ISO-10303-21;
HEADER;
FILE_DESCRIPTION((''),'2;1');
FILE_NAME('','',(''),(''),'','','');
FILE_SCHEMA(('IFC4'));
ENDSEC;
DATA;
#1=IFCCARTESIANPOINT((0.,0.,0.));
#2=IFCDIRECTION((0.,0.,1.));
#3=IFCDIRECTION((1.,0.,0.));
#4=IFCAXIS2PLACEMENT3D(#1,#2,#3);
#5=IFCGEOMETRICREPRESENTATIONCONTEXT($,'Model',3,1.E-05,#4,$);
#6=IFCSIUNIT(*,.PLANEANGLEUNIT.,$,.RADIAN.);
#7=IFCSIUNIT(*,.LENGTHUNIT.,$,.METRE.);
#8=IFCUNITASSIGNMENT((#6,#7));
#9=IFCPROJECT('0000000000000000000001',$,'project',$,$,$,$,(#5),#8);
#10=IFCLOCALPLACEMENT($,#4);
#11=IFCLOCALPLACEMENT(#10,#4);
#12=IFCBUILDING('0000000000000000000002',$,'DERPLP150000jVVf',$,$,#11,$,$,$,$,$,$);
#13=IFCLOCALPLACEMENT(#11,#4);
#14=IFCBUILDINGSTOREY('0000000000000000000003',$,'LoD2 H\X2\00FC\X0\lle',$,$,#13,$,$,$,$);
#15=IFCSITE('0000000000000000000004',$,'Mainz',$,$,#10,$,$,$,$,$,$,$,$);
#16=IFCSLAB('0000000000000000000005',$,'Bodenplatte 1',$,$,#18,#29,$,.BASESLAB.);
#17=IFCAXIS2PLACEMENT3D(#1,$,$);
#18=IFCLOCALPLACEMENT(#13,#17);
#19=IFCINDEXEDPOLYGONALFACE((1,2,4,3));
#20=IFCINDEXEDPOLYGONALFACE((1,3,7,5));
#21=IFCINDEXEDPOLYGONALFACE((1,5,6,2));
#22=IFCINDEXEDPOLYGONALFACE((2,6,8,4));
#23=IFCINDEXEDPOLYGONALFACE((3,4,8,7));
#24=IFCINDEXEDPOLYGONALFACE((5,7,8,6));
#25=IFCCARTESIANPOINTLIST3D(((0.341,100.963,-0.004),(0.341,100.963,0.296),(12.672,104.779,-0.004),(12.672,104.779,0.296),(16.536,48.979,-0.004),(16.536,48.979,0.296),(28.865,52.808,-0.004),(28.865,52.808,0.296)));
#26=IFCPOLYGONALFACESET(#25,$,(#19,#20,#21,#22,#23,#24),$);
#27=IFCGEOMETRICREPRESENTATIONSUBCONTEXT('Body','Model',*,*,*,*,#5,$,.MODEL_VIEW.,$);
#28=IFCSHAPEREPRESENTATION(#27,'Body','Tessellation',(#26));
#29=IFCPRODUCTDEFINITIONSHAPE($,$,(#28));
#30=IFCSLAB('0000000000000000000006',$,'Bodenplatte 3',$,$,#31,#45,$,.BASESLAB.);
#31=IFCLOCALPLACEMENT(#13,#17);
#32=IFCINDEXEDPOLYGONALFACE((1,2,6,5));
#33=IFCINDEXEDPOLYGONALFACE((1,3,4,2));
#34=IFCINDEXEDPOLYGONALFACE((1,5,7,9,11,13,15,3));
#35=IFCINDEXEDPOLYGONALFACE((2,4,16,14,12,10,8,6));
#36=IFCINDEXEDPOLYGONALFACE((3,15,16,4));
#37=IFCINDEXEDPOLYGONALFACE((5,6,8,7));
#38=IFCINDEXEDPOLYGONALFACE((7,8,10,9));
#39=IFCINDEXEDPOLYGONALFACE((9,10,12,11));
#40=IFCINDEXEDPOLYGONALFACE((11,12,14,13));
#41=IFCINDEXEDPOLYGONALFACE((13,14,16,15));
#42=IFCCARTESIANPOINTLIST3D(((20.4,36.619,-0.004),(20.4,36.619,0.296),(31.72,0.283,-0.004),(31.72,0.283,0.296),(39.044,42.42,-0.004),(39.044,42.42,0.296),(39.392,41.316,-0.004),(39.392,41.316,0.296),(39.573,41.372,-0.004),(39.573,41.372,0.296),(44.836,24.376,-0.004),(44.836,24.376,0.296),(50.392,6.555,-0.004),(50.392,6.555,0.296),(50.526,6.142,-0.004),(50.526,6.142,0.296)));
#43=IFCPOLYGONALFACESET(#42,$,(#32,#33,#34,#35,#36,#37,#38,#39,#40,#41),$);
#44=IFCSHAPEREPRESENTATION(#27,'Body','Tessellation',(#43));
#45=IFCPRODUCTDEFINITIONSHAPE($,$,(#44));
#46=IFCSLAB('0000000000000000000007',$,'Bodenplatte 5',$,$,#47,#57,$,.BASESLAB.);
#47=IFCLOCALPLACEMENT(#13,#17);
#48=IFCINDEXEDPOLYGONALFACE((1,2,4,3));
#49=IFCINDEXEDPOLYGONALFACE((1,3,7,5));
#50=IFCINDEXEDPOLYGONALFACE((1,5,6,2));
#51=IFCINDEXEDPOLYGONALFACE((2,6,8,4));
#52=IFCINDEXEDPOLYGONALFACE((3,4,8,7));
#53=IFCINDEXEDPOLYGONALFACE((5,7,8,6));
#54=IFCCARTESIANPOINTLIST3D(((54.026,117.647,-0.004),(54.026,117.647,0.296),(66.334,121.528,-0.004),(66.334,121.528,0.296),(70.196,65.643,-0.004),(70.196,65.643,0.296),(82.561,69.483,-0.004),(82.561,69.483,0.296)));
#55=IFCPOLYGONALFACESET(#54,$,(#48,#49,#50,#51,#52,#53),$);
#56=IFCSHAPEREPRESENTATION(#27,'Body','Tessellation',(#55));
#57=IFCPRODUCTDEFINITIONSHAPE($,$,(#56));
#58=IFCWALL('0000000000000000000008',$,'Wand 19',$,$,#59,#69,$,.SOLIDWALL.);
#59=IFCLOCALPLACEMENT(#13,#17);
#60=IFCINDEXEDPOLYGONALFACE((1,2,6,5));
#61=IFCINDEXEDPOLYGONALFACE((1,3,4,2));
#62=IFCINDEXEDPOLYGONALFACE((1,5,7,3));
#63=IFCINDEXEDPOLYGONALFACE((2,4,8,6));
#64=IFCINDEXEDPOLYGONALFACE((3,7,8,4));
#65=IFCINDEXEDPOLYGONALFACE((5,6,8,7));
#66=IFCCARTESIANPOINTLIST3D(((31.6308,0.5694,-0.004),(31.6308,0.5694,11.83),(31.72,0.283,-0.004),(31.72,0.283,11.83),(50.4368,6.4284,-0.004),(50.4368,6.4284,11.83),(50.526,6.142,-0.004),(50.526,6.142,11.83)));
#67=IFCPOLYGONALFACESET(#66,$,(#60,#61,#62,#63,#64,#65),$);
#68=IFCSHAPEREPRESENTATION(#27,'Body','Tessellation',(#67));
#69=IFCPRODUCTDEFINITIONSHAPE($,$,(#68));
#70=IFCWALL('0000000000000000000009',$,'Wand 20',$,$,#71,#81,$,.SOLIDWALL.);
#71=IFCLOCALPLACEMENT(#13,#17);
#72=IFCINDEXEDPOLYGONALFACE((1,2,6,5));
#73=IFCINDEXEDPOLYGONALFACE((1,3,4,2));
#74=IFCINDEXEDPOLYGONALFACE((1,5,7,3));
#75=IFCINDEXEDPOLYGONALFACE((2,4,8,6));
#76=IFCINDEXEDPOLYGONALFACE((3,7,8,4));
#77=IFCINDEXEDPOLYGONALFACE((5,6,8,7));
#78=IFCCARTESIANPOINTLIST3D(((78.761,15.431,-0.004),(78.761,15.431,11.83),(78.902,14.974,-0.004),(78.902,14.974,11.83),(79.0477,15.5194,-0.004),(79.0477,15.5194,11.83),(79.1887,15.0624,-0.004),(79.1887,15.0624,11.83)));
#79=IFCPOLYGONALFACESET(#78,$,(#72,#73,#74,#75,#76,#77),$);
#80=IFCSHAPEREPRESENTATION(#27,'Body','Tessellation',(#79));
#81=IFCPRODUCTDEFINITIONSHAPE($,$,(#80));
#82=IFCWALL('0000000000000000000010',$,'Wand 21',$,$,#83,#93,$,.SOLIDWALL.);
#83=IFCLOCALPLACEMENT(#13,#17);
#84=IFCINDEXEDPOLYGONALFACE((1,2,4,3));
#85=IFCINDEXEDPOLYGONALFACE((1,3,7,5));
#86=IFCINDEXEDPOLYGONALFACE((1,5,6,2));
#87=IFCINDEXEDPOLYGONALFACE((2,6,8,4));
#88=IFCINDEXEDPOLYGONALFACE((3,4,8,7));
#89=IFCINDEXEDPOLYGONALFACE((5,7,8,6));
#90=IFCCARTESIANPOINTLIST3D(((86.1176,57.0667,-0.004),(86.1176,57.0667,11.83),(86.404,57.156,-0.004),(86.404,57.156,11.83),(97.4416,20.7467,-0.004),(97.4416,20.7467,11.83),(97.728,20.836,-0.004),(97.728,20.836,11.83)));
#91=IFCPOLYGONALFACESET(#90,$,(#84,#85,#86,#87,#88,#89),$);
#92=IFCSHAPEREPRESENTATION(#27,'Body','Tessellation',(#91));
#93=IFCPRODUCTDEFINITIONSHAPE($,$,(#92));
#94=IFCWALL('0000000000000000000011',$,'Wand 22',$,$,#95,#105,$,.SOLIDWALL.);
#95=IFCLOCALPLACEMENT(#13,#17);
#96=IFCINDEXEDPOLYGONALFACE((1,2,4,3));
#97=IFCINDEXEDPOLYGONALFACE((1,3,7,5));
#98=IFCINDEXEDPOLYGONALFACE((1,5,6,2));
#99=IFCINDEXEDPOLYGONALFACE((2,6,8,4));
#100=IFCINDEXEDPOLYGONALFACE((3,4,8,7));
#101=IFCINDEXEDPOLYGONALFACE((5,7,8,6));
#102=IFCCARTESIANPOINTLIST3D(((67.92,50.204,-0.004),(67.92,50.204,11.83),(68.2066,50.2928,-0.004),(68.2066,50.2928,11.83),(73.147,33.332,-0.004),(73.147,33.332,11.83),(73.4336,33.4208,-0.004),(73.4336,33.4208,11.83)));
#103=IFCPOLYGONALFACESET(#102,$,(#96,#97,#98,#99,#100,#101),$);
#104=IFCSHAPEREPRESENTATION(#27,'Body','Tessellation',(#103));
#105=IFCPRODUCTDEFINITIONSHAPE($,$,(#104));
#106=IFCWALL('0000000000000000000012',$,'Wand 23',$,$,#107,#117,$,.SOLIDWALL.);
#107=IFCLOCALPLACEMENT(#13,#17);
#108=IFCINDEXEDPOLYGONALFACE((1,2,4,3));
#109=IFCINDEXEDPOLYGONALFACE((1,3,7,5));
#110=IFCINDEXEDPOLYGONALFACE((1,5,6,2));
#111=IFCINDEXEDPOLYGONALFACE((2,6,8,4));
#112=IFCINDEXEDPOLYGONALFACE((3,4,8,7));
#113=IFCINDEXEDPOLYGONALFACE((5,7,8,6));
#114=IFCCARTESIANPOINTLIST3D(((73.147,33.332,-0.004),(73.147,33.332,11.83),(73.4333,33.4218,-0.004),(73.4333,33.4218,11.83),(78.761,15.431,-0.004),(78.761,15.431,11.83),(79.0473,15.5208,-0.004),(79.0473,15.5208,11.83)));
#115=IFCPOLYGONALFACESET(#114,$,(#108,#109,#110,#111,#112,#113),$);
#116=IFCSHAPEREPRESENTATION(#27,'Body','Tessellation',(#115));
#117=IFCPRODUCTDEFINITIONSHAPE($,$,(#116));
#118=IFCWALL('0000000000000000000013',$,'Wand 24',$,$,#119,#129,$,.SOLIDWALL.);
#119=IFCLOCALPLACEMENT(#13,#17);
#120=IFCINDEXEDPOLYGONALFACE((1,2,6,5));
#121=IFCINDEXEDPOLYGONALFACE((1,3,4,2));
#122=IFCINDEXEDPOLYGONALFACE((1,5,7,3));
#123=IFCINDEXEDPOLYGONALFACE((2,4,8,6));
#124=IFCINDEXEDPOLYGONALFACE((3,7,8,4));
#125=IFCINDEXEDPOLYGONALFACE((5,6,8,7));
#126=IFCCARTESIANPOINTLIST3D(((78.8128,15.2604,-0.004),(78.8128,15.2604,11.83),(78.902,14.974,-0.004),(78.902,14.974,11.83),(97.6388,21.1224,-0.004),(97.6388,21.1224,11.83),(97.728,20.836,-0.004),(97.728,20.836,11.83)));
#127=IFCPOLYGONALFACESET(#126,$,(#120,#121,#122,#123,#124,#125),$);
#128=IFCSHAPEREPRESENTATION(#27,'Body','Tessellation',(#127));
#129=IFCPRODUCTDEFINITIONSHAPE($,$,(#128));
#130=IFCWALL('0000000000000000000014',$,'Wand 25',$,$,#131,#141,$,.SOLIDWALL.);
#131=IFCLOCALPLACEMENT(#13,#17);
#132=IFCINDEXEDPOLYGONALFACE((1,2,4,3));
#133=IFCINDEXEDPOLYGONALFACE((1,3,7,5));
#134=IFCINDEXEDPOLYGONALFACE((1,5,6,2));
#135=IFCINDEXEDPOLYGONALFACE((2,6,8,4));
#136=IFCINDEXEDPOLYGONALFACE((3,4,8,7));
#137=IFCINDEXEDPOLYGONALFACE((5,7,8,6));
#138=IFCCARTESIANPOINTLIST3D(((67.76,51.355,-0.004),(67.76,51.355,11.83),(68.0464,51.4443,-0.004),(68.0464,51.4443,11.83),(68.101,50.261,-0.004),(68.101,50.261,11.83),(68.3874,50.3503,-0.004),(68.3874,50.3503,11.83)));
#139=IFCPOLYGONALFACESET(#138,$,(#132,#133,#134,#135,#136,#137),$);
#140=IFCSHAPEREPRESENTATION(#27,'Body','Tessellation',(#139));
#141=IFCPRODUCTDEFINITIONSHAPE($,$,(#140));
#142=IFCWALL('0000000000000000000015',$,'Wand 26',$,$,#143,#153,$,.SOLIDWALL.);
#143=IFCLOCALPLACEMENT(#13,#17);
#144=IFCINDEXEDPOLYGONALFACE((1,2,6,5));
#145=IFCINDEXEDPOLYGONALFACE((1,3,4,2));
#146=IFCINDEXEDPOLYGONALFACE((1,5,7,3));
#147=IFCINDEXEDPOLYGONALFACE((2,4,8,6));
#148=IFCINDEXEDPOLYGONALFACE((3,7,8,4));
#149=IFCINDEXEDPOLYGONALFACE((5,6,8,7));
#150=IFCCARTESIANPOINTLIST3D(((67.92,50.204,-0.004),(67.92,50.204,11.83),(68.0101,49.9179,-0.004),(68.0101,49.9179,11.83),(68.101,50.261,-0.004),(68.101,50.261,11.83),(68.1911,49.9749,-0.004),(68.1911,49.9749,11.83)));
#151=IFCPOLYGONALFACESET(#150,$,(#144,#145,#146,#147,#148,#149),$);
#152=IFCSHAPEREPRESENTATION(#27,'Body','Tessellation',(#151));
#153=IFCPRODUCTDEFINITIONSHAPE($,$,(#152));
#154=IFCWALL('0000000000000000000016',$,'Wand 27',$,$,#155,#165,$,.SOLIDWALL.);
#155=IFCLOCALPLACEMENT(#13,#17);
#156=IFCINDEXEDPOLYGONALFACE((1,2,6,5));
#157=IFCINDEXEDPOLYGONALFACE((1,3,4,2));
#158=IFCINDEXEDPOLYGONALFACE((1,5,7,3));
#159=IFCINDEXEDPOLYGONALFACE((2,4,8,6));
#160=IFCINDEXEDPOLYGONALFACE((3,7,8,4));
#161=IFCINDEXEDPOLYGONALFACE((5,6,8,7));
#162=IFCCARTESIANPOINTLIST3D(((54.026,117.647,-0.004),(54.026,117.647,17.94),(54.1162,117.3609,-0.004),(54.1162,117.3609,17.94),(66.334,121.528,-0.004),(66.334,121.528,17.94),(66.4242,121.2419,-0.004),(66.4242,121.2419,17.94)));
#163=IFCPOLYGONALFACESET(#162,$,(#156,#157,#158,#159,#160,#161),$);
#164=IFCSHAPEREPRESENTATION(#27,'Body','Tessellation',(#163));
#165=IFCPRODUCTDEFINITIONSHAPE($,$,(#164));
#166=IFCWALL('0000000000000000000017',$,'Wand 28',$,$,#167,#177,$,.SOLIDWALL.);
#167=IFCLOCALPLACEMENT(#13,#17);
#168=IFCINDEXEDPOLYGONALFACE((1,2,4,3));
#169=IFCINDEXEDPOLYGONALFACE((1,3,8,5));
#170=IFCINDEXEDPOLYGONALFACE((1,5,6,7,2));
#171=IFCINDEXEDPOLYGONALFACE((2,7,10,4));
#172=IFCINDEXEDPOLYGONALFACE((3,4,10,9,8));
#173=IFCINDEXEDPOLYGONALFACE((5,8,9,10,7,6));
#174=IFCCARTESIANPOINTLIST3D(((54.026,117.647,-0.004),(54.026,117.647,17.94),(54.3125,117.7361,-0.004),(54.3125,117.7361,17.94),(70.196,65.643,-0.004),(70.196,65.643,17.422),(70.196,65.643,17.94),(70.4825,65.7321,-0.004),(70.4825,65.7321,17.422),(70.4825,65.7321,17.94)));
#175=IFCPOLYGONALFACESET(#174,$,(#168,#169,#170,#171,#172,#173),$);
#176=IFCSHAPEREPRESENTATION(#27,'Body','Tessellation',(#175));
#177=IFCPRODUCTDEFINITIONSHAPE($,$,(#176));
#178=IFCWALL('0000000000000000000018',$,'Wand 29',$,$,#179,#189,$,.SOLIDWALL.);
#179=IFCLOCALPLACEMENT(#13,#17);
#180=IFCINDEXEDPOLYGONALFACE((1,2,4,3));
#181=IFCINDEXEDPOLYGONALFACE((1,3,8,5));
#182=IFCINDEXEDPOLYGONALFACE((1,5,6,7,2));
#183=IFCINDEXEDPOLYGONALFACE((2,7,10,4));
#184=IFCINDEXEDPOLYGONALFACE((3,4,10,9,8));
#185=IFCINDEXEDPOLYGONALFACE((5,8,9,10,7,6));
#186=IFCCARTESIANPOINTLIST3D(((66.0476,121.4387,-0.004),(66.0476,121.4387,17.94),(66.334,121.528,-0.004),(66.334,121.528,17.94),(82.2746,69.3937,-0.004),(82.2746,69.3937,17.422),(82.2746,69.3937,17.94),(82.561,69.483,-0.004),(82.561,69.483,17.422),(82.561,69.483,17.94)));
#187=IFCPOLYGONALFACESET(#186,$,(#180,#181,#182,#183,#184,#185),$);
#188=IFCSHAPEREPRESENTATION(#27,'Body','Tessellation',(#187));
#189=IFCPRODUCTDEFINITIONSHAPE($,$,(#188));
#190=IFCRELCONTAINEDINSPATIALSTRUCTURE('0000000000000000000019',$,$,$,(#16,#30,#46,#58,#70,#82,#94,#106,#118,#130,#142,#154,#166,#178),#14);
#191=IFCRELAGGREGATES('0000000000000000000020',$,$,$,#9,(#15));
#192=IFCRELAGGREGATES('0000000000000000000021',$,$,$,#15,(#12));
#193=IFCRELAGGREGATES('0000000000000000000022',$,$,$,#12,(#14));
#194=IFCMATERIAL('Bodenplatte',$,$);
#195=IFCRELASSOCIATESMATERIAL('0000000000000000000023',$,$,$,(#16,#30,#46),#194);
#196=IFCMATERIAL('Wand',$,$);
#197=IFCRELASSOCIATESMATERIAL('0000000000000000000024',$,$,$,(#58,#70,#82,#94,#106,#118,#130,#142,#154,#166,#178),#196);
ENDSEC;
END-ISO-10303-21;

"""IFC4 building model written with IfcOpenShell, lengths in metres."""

from ifc_helpers import new_model, si_unit, frame, origin_with_axes, place, context, subcontext, project, spatial, polyline, outline, extrude, material, element, save


model = new_model("IFC4")

# Units and contexts
model_context = context("Model", 3, precision=1e-05, world=origin_with_axes())
body_context = subcontext(model_context, "Body", "Model", "MODEL_VIEW")
ifc_project = project(units=[si_unit("PLANEANGLEUNIT", "RADIAN"), si_unit("LENGTHUNIT", "METRE")], contexts=[model_context])

# Site, building, storey
site_placement = place(None, origin_with_axes())
site = spatial("IfcSite", under=ifc_project, at=site_placement, Name="Mainz")
building_placement = place(site_placement, origin_with_axes())
building = spatial("IfcBuilding", under=site, at=building_placement, Name="DERPLP150000jVVf")
storey_placement = place(building_placement, origin_with_axes())
storey = spatial("IfcBuildingStorey", under=building, at=storey_placement, Name="LoD2 Hülle")

# Slabs
ifc_material_1 = material(Name="Bodenplatte")
slab_1_placement = place(storey_placement, origin_with_axes())
element("IfcSlab", 1, at=slab_1_placement, inside=storey, material=ifc_material_1, Name="Bodenplatte 1", PredefinedType="BASESLAB", context=body_context, shape_type="SweptSolid", body=[
    extrude(outline(polyline([(0.0, 0.0), (54.4353, 0.0), (54.4234, 12.9099), (-0.0249, 12.9079), (0.0, 0.0)])), frame((12.672, 104.779, -0.004), z_axis=(0.0, 0.0, -1.0), x_axis=(0.297473, -0.95473, 0.0)), (0.0, 0.0, -1.0), 0.3),
])
slab_2_placement = place(storey_placement, origin_with_axes())
element("IfcSlab", 2, at=slab_2_placement, inside=storey, material=ifc_material_1, Name="Bodenplatte 3", PredefinedType="BASESLAB", context=body_context, shape_type="SweptSolid", body=[
    extrude(outline(polyline([(0.0, 0.0), (38.0585, 0.0), (38.0515, 19.5256), (36.894, 19.5295), (36.8936, 19.719), (19.1014, 19.6885), (0.4344, 19.6925), (0.0002, 19.6976), (0.0, 0.0)])), frame((31.72, 0.283, -0.004), z_axis=(0.0, 0.0, -1.0), x_axis=(-0.297437, 0.954741, 0.0)), (0.0, 0.0, -1.0), 0.3),
])
slab_3_placement = place(storey_placement, origin_with_axes())
element("IfcSlab", 3, at=slab_3_placement, inside=storey, material=ifc_material_1, Name="Bodenplatte 5", PredefinedType="BASESLAB", context=body_context, shape_type="SweptSolid", body=[
    extrude(outline(polyline([(0.0, 0.0), (54.4599, 0.0), (54.5115, 12.9053), (-0.0045, 12.9475), (0.0, 0.0)])), frame((70.196, 65.643, -0.004), z_axis=(0.0, 0.0, -1.0), x_axis=(-0.296916, 0.954904, 0.0)), (0.0, 0.0, -1.0), 0.3),
])

# Walls
ifc_material_2 = material(Name="Wand")
wall_1_placement = place(storey_placement, origin_with_axes())
element("IfcWall", 4, at=wall_1_placement, inside=storey, material=ifc_material_2, Name="Wand 19", PredefinedType="SOLIDWALL", context=body_context, shape_type="SweptSolid", body=[
    extrude(outline(polyline([(0.0, 0.0), (19.6976, 0.0), (19.6976, 11.834), (0.0, 11.834), (0.0, 0.0)])), frame((50.526, 6.142, 11.83), z_axis=(0.297448, -0.954738, 0.0), x_axis=(-0.954738, -0.297448, 0.0)), (0.0, 0.0, -1.0), 0.3),
])
wall_2_placement = place(storey_placement, origin_with_axes())
element("IfcWall", 5, at=wall_2_placement, inside=storey, material=ifc_material_2, Name="Wand 20", PredefinedType="SOLIDWALL", context=body_context, shape_type="SweptSolid", body=[
    extrude(outline(polyline([(0.0, 0.0), (0.4783, 0.0), (0.4783, 11.834), (0.0, 11.834), (0.0, 0.0)])), frame((78.902, 14.974, 11.83), z_axis=(-0.955553, -0.29482, 0.0), x_axis=(-0.29482, 0.955553, 0.0)), (0.0, 0.0, -1.0), 0.3),
])
wall_3_placement = place(storey_placement, origin_with_axes())
element("IfcWall", 6, at=wall_3_placement, inside=storey, material=ifc_material_2, Name="Wand 21", PredefinedType="SOLIDWALL", context=body_context, shape_type="SweptSolid", body=[
    extrude(outline(polyline([(0.0, 0.0), (38.0444, 0.0), (38.0444, 11.834), (0.0, 11.834), (0.0, 0.0)])), frame((86.404, 57.156, 11.83), z_axis=(0.954674, 0.297652, 0.0), x_axis=(0.297652, -0.954674, 0.0)), (0.0, 0.0, -1.0), 0.3),
])
wall_4_placement = place(storey_placement, origin_with_axes())
element("IfcWall", 7, at=wall_4_placement, inside=storey, material=ifc_material_2, Name="Wand 22", PredefinedType="SOLIDWALL", context=body_context, shape_type="SweptSolid", body=[
    extrude(outline(polyline([(0.0, 0.0), (17.6631, 0.0), (17.6631, 11.834), (0.0, 11.834), (0.0, 0.0)])), frame((73.147, 33.332, 11.83), z_axis=(-0.95521, -0.295927, 0.0), x_axis=(-0.295927, 0.95521, 0.0)), (0.0, 0.0, -1.0), 0.3),
])
wall_5_placement = place(storey_placement, origin_with_axes())
element("IfcWall", 8, at=wall_5_placement, inside=storey, material=ifc_material_2, Name="Wand 23", PredefinedType="SOLIDWALL", context=body_context, shape_type="SweptSolid", body=[
    extrude(outline(polyline([(0.0, 0.0), (18.7607, 0.0), (18.7607, 11.834), (0.0, 11.834), (0.0, 0.0)])), frame((78.761, 15.431, 11.83), z_axis=(-0.954177, -0.299243, 0.0), x_axis=(-0.299243, 0.954177, 0.0)), (0.0, 0.0, -1.0), 0.3),
])
wall_6_placement = place(storey_placement, origin_with_axes())
element("IfcWall", 9, at=wall_6_placement, inside=storey, material=ifc_material_2, Name="Wand 24", PredefinedType="SOLIDWALL", context=body_context, shape_type="SweptSolid", body=[
    extrude(outline(polyline([(0.0, 0.0), (19.7175, 0.0), (19.7175, 11.834), (0.0, 11.834), (0.0, 0.0)])), frame((97.728, 20.836, 11.83), z_axis=(0.297299, -0.954784, 0.0), x_axis=(-0.954784, -0.297299, 0.0)), (0.0, 0.0, -1.0), 0.3),
])
wall_7_placement = place(storey_placement, origin_with_axes())
element("IfcWall", 10, at=wall_7_placement, inside=storey, material=ifc_material_2, Name="Wand 25", PredefinedType="SOLIDWALL", context=body_context, shape_type="SweptSolid", body=[
    extrude(outline(polyline([(0.0, 0.0), (1.1459, 0.0), (1.1459, 11.834), (0.0, 11.834), (0.0, 0.0)])), frame((68.101, 50.261, 11.83), z_axis=(-0.954697, -0.297579, 0.0), x_axis=(-0.297579, 0.954697, 0.0)), (0.0, 0.0, -1.0), 0.3),
])
wall_8_placement = place(storey_placement, origin_with_axes())
element("IfcWall", 11, at=wall_8_placement, inside=storey, material=ifc_material_2, Name="Wand 26", PredefinedType="SOLIDWALL", context=body_context, shape_type="SweptSolid", body=[
    extrude(outline(polyline([(0.0, 0.0), (0.1898, 0.0), (0.1898, 11.834), (0.0, 11.834), (0.0, 0.0)])), frame((67.92, 50.204, 11.83), z_axis=(-0.300375, 0.953821, 0.0), x_axis=(0.953821, 0.300375, 0.0)), (0.0, 0.0, -1.0), 0.3),
])
wall_9_placement = place(storey_placement, origin_with_axes())
element("IfcWall", 12, at=wall_9_placement, inside=storey, material=ifc_material_2, Name="Wand 27", PredefinedType="SOLIDWALL", context=body_context, shape_type="SweptSolid", body=[
    extrude(outline(polyline([(0.0, 0.0), (12.9054, 0.0), (12.9054, 17.944), (0.0, 17.944), (0.0, 0.0)])), frame((54.026, 117.647, 17.94), z_axis=(-0.300727, 0.95371, 0.0), x_axis=(0.95371, 0.300727, 0.0)), (0.0, 0.0, -1.0), 0.3),
])
wall_10_placement = place(storey_placement, origin_with_axes())
element("IfcWall", 13, at=wall_10_placement, inside=storey, material=ifc_material_2, Name="Wand 28", PredefinedType="SOLIDWALL", context=body_context, shape_type="SweptSolid", body=[
    extrude(outline(polyline([(0.0, 0.0), (54.4599, 0.0), (54.4599, 17.944), (0.0, 17.944), (0.0, 0.518), (0.0, 0.0)])), frame((70.196, 65.643, 17.94), z_axis=(-0.954904, -0.296916, 0.0), x_axis=(-0.296916, 0.954904, 0.0)), (0.0, 0.0, -1.0), 0.3),
])
wall_11_placement = place(storey_placement, origin_with_axes())
element("IfcWall", 14, at=wall_11_placement, inside=storey, material=ifc_material_2, Name="Wand 29", PredefinedType="SOLIDWALL", context=body_context, shape_type="SweptSolid", body=[
    extrude(outline(polyline([(0.0, 0.0), (54.516, 0.0), (54.516, 0.518), (54.516, 17.944), (0.0, 17.944), (0.0, 0.0)])), frame((66.334, 121.528, 17.94), z_axis=(0.954673, 0.297656, 0.0), x_axis=(0.297656, -0.954673, 0.0)), (0.0, 0.0, -1.0), 0.3),
])

save(model, "model.ifc")
